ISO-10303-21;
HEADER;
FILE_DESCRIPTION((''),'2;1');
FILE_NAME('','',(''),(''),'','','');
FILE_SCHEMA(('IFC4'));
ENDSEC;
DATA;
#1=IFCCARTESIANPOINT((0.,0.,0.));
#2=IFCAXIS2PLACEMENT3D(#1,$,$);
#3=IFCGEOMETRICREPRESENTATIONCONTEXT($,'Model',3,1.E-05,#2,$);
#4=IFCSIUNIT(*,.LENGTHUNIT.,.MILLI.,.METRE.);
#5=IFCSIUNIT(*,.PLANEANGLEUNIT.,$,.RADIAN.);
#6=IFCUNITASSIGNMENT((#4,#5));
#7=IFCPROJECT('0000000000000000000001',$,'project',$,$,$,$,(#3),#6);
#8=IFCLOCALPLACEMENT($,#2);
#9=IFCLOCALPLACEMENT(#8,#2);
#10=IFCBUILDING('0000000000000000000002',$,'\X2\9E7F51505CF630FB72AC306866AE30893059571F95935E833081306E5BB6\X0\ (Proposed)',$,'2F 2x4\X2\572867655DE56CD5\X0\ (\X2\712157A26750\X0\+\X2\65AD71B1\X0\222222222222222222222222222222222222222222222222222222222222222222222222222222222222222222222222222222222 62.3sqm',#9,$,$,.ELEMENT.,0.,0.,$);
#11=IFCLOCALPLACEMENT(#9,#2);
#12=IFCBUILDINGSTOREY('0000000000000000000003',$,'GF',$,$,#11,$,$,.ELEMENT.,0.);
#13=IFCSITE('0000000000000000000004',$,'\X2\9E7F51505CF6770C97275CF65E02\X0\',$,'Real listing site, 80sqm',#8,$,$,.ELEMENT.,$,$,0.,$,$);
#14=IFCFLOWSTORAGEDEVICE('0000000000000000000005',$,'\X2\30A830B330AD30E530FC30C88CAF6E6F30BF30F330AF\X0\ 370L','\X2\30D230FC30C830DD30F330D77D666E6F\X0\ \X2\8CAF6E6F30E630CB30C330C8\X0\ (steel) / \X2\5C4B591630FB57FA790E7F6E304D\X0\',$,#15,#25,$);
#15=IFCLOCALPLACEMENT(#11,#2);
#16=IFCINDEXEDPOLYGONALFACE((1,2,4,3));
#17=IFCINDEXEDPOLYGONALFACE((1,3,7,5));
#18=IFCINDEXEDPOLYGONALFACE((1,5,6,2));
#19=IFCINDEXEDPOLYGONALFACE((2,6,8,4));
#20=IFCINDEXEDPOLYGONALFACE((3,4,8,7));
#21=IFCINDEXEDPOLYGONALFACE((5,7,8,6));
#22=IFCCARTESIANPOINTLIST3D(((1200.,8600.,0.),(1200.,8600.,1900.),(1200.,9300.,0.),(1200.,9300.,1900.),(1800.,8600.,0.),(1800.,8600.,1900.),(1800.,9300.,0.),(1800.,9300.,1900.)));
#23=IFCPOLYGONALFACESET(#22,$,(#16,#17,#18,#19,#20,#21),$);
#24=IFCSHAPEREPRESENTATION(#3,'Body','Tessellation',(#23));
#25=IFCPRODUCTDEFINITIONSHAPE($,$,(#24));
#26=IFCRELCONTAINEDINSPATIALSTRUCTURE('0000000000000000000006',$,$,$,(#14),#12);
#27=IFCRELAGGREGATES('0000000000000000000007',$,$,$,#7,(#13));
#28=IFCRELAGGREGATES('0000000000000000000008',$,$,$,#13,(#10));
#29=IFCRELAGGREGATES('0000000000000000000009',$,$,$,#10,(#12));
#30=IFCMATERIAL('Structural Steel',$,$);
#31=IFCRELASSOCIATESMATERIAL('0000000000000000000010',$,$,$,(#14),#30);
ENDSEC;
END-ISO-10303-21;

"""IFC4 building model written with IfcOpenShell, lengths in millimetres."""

from ifc_helpers import new_model, si_unit, frame, frame_2d, origin, place, context, project, spatial, rectangle, extrude, material, element, save


model = new_model("IFC4")

# Units and contexts
model_context = context("Model", 3, precision=1e-05, world=origin())
ifc_project = project(units=[si_unit("LENGTHUNIT", "METRE", prefix="MILLI"), si_unit("PLANEANGLEUNIT", "RADIAN")], contexts=[model_context])

# Site, building, storey
site_placement = place(None, origin())
site = spatial("IfcSite", under=ifc_project, at=site_placement, Name="鹿児島県霧島市", ObjectType="Real listing site, 80sqm", CompositionType="ELEMENT", RefElevation=0.0)
building_placement = place(site_placement, origin())
building = spatial("IfcBuilding", under=site, at=building_placement, Name="鹿児島・犬と暮らす土間広めの家 (Proposed)", ObjectType="2F 2x4在来工法 (無垢材+断熱222222222222222222222222222222222222222222222222222222222222222222222222222222222222222222222222222222222 62.3sqm", CompositionType="ELEMENT", ElevationOfRefHeight=0.0, ElevationOfTerrain=0.0)
storey_placement = place(building_placement, origin())
storey = spatial("IfcBuildingStorey", under=building, at=storey_placement, Name="GF", CompositionType="ELEMENT", Elevation=0.0)

# Flow storage device
ifc_material_1 = material(Name="Structural Steel")
flow_storage_device_placement = place(storey_placement, frame((600.0, 4300.0, 0.0)))
element("IfcFlowStorageDevice", 1, at=flow_storage_device_placement, inside=storey, material=ifc_material_1, Name="エコキュート貯湯タンク 370L", Description="ヒートポンプ給湯 貯湯ユニット (steel) / 屋外・基礎置き", context=model_context, shape_type="SweptSolid", body=[
    extrude(rectangle(XDim=600.0, YDim=700.0, at=frame_2d((300.0, 350.0))), frame((600.0, 4300.0, 0.0)), (0.0, 0.0, 1.0), 1900.0),
])

save(model, "model.ifc")
